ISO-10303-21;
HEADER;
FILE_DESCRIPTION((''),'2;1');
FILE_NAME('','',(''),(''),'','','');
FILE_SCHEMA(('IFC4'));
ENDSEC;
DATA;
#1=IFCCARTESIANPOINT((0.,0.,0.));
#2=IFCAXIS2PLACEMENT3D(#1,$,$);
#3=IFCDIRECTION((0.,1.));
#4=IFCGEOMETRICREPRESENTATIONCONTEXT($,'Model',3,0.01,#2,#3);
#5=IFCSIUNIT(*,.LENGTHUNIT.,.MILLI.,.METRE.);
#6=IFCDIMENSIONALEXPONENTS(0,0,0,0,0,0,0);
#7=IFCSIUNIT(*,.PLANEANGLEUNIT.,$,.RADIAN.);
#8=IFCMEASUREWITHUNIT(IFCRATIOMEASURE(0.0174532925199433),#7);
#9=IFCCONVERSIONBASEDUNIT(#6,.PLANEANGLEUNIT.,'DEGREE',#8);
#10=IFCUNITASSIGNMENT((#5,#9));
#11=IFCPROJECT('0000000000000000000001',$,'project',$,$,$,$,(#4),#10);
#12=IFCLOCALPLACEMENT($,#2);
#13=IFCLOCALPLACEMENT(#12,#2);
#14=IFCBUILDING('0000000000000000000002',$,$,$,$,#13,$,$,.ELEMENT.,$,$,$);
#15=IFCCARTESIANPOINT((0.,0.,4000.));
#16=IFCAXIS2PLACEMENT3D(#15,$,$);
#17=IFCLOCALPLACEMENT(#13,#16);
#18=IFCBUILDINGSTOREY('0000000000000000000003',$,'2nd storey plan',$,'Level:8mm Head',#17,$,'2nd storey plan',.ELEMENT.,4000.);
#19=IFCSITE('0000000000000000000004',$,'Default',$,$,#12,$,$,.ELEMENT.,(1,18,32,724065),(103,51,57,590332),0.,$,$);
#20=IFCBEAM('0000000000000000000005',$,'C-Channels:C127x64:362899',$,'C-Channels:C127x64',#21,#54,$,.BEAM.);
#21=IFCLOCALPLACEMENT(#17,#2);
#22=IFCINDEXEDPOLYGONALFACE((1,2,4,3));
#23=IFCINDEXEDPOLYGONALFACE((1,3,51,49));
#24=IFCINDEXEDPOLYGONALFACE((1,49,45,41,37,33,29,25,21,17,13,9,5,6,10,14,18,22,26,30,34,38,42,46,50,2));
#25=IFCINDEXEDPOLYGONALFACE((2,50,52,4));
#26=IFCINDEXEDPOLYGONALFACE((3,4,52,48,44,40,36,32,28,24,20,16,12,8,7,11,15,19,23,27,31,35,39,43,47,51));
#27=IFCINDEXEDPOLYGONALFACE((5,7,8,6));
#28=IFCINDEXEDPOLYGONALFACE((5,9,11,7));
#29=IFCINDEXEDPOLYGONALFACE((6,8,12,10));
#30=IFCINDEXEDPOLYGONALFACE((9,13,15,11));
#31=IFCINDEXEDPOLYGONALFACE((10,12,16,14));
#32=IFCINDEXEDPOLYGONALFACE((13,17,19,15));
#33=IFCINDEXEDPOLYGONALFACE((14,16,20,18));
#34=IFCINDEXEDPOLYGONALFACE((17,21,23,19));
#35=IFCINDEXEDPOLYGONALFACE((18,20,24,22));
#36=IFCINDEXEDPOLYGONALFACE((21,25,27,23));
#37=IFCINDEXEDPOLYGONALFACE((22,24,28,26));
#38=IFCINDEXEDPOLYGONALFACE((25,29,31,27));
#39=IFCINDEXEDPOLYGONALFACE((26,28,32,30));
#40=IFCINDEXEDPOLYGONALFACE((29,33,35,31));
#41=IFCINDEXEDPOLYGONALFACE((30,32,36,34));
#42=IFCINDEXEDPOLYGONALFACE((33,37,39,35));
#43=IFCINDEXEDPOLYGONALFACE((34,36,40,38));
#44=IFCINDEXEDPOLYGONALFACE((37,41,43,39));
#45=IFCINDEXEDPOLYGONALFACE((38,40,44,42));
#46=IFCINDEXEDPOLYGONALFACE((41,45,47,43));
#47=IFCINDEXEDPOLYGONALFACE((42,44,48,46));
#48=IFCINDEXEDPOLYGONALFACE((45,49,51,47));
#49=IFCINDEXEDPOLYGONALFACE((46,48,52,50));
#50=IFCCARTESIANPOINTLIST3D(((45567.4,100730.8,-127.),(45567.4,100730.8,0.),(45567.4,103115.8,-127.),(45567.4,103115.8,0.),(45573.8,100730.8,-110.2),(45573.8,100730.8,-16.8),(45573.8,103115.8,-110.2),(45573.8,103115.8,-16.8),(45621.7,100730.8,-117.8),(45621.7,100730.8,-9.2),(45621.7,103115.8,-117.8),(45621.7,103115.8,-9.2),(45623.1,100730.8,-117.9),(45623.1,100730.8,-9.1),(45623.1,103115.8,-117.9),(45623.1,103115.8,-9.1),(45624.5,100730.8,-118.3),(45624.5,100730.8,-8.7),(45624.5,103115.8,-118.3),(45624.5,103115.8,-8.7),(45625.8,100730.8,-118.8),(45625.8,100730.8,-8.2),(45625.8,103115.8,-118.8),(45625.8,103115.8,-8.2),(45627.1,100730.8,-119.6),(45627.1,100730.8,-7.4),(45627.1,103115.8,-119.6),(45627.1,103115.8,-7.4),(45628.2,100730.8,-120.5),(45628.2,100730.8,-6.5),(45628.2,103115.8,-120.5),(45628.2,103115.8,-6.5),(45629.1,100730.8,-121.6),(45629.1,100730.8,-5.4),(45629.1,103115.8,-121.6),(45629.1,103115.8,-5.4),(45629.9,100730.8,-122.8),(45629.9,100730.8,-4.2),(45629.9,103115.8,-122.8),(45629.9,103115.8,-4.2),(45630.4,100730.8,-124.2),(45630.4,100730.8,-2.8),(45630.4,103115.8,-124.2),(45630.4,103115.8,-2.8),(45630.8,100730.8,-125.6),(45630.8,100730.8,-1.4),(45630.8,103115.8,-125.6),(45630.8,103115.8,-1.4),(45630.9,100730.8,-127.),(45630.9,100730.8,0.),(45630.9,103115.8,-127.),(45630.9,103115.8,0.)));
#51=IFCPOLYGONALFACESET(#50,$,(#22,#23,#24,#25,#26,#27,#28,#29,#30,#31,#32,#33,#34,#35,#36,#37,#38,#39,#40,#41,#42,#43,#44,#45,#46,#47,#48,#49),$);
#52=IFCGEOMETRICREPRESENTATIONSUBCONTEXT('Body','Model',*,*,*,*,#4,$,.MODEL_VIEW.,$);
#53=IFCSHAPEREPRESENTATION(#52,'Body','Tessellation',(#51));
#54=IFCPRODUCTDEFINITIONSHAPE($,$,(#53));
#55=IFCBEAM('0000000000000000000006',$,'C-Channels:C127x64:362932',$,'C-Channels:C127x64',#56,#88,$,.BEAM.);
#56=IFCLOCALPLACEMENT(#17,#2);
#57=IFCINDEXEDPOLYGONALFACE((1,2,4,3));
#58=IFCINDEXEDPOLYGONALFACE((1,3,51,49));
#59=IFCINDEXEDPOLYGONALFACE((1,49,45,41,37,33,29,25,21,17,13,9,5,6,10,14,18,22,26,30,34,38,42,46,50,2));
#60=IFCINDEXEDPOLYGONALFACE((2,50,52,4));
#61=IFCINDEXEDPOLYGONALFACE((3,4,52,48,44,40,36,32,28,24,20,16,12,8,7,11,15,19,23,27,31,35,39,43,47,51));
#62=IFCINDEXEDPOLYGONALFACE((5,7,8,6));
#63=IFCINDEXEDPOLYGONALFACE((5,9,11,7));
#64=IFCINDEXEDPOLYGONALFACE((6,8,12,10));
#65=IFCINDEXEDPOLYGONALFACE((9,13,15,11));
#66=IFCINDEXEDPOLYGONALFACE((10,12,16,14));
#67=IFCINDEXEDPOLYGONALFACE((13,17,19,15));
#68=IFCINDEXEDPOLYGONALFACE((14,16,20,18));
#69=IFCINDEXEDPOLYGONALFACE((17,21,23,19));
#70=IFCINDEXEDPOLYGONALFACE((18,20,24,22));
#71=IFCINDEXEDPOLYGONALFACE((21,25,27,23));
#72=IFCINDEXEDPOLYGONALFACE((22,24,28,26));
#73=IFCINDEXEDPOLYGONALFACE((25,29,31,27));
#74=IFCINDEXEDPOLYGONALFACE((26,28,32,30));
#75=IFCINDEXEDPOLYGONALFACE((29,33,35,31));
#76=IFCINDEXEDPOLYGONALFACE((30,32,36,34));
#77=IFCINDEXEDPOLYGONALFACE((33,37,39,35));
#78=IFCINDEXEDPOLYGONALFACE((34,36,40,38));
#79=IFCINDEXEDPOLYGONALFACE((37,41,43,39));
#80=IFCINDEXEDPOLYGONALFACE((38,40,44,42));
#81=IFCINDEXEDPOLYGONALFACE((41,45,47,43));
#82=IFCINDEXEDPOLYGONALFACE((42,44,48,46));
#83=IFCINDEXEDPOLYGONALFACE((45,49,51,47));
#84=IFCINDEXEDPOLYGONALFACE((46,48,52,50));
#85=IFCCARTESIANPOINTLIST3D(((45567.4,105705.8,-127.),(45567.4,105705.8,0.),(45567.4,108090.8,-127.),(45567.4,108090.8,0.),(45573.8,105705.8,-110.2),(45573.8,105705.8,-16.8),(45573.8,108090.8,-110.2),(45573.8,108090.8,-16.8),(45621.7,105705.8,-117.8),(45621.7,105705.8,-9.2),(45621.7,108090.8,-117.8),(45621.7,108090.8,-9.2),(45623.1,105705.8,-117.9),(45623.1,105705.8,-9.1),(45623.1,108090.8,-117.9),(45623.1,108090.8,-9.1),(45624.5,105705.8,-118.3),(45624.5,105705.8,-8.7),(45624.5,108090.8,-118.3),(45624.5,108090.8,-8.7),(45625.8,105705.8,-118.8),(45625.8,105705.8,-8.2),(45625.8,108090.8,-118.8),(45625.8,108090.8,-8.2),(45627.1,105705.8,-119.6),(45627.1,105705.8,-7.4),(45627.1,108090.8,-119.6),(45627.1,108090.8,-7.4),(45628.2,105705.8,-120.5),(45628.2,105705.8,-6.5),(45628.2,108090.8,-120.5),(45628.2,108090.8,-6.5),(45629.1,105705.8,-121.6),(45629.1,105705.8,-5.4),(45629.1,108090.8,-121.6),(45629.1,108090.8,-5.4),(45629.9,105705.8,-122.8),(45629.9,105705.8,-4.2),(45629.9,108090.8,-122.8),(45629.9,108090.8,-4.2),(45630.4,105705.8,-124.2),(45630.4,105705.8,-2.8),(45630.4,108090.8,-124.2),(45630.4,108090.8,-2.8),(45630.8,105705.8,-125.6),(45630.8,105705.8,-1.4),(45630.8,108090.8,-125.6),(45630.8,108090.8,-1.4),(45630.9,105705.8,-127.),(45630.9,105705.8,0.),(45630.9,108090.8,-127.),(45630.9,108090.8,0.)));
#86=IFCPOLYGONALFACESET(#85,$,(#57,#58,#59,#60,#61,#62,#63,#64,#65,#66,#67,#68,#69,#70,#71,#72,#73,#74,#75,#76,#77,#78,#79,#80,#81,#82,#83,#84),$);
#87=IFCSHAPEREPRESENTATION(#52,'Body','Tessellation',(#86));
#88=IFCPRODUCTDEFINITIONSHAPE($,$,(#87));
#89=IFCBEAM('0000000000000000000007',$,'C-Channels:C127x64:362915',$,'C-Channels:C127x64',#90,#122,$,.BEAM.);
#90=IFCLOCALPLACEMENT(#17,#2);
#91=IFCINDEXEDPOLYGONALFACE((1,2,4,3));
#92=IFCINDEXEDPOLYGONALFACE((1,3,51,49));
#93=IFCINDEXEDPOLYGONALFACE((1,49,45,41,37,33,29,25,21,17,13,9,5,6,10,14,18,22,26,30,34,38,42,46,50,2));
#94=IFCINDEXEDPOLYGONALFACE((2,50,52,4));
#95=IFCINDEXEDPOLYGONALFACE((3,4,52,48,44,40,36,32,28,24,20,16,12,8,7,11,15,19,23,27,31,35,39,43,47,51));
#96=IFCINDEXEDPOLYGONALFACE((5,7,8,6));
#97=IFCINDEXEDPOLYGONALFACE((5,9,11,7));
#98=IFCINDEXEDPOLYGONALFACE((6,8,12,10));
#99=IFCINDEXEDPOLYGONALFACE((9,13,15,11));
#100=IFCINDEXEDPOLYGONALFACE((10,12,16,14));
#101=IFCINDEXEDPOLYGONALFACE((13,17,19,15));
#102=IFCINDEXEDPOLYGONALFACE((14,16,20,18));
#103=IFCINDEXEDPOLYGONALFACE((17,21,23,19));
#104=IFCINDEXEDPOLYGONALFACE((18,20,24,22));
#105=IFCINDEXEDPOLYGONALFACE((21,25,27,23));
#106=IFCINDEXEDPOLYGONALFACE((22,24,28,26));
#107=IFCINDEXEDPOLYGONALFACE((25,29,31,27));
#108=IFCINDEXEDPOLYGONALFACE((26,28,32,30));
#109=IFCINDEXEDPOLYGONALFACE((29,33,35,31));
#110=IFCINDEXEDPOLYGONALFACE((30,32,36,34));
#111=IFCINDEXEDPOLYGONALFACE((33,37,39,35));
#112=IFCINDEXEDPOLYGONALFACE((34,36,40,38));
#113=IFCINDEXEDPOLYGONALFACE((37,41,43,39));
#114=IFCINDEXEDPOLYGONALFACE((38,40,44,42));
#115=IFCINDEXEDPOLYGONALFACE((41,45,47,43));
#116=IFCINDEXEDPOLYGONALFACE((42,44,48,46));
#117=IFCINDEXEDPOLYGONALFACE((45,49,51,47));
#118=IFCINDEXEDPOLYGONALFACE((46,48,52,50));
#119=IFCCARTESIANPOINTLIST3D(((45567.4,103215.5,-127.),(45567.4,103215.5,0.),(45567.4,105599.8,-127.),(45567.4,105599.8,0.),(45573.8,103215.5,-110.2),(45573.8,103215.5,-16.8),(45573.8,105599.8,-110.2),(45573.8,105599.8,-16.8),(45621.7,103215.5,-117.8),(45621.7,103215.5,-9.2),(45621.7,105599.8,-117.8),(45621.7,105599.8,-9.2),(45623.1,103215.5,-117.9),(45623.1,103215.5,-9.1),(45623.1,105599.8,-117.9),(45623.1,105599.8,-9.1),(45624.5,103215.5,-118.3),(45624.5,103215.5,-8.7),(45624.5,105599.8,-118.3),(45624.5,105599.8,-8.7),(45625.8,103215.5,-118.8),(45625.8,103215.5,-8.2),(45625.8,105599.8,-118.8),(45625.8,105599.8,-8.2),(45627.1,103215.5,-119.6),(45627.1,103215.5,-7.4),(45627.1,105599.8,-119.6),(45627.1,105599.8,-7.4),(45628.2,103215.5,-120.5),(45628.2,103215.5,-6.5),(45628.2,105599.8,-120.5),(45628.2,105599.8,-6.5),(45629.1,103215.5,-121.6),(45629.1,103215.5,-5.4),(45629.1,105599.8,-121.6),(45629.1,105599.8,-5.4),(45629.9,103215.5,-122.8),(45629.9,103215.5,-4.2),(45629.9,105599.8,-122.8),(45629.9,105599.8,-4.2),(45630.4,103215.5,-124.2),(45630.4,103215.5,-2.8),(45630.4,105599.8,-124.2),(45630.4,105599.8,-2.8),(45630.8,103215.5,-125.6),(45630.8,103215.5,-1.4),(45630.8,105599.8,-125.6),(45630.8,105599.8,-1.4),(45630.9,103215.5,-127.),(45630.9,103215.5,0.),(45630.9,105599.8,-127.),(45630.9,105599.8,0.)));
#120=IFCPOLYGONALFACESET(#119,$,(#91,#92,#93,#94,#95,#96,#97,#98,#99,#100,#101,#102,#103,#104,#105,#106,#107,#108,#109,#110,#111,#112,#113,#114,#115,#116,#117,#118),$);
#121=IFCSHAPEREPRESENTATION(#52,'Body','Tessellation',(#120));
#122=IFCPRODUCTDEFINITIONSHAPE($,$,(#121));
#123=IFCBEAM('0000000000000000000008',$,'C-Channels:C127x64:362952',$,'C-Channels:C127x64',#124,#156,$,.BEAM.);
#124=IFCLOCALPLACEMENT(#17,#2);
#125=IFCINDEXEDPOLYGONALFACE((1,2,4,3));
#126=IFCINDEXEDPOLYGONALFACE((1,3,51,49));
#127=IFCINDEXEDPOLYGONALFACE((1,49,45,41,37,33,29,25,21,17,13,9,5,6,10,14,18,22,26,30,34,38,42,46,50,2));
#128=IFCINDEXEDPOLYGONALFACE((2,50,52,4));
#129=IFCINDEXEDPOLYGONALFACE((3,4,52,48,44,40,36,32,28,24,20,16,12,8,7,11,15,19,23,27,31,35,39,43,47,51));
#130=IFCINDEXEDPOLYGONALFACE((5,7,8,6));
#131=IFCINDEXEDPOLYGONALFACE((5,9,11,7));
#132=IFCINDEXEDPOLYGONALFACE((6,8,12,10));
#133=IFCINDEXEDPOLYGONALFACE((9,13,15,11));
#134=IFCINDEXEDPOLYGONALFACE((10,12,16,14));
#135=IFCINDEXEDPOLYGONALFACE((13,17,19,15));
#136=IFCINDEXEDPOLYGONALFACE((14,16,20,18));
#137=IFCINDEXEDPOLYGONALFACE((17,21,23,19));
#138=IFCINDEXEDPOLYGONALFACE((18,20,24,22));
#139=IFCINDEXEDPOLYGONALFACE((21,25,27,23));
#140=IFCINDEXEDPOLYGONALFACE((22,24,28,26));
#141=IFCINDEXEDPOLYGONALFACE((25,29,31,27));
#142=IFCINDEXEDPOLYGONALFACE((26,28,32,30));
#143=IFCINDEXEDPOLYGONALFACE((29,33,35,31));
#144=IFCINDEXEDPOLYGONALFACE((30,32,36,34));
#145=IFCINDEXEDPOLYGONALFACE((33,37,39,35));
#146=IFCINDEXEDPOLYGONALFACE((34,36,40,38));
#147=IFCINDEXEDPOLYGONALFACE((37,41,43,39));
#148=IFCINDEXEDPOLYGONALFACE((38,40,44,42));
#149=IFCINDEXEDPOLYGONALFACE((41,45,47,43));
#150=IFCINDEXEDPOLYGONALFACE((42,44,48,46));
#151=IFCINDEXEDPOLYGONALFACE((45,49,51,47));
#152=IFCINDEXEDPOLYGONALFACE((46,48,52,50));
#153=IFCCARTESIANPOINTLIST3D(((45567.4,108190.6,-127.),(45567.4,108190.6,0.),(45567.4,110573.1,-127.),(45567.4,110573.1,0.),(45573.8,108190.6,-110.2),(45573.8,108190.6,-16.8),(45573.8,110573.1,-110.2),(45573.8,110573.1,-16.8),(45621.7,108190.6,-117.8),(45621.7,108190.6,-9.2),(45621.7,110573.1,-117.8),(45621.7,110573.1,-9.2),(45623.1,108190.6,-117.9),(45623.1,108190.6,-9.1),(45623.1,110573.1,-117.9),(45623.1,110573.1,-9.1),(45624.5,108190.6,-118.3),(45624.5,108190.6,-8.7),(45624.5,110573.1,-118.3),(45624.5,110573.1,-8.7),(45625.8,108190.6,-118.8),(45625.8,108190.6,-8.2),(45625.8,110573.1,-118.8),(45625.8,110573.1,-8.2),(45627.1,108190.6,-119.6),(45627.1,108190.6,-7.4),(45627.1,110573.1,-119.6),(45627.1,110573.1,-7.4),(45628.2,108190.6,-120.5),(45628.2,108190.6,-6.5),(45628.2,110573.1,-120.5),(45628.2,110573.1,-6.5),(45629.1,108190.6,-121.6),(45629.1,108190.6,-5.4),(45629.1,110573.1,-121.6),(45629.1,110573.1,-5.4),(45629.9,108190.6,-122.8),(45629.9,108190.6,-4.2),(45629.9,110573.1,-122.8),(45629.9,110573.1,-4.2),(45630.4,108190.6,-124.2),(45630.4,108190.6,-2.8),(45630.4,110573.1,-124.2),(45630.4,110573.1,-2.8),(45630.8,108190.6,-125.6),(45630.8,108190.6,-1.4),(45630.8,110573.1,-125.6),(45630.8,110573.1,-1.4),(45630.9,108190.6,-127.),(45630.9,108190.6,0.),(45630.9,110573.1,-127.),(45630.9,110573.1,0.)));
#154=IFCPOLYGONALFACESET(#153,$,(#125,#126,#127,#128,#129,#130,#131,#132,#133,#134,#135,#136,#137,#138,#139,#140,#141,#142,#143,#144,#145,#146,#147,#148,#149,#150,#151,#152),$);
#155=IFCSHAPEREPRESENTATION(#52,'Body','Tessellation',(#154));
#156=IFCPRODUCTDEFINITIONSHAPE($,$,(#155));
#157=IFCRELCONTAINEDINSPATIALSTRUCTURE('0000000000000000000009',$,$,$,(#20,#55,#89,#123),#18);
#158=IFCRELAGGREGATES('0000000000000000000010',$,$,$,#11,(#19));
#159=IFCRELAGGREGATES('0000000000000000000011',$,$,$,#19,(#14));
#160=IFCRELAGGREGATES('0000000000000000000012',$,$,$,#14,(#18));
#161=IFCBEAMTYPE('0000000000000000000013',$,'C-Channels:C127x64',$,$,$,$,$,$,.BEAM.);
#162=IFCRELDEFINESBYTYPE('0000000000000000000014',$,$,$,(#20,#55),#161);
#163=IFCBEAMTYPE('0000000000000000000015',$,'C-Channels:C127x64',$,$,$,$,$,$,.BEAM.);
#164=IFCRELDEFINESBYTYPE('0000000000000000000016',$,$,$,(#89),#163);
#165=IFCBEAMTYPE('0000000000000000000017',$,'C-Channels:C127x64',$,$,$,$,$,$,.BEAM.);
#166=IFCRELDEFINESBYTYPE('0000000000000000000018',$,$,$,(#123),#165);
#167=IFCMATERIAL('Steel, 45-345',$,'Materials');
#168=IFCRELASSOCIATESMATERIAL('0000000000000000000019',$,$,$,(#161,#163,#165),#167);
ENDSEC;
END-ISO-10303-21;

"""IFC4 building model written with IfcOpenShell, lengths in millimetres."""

from ifc_helpers import new_model, entity, si_unit, converted_unit, direction, frame, origin, place, context, subcontext, project, spatial, indexed_curve, outline, extrude, source, transform, mapped, material, type_object, type_shapes, element, save


model = new_model("IFC4")

# Units and contexts
model_context = context("Model", 3, precision=0.01, world=origin(), true_north=direction((0.0, 1.0)))
body_context = subcontext(model_context, "Body", "Model", "MODEL_VIEW")
ifc_project = project(units=[si_unit("LENGTHUNIT", "METRE", prefix="MILLI"), converted_unit("PLANEANGLEUNIT", "DEGREE", entity("IfcRatioMeasure", 0.0174532925199433), si_unit("PLANEANGLEUNIT", "RADIAN"), dimensions=[0, 0, 0, 0, 0, 0, 0])], contexts=[model_context])

# Site, building, storey
site_placement = place(None, origin())
site = spatial("IfcSite", under=ifc_project, at=site_placement, Name="Default", CompositionType="ELEMENT", RefLatitude=(1, 18, 32, 724065), RefLongitude=(103, 51, 57, 590332), RefElevation=0.0)
building_placement = place(site_placement, origin())
building = spatial("IfcBuilding", under=site, at=building_placement, CompositionType="ELEMENT")
storey_placement = place(building_placement, frame((0.0, 0.0, 4000.0)))
storey = spatial("IfcBuildingStorey", under=building, at=storey_placement, Name="2nd storey plan", ObjectType="Level:8mm Head", LongName="2nd storey plan", CompositionType="ELEMENT", Elevation=4000.0)

# Beams
ifc_material_1 = material(Name="Steel, 45-345", Category="Materials")
beam_type_1 = type_object("IfcBeamType", Name="C-Channels:C127x64", PredefinedType="BEAM", material=ifc_material_1)
shared_shape_1 = source(origin(), body_context, "Body", "SweptSolid", [
    extrude(outline(indexed_curve([(-32.5, -63.5), (31.0, -63.5), (31.0, 63.5), (-32.4, 63.5), (-32.3, 62.1), (-32.0, 60.7), (-31.4, 59.3), (-30.7, 58.1), (-29.8, 57.0), (-28.7, 56.1), (-27.4, 55.3), (-26.1, 54.8), (-24.7, 54.4), (-23.2, 54.3), (24.6, 46.7), (24.6, -46.7), (-23.2, -54.3), (-24.7, -54.4), (-26.1, -54.8), (-27.4, -55.3), (-28.7, -56.1), (-29.8, -57.0), (-30.7, -58.1), (-31.4, -59.3), (-32.0, -60.7), (-32.3, -62.1), (-32.5, -63.5)], self_intersect=False)), frame((-1192.5, -11.7, 0.0), z_axis=(1.0, 0.0, 0.0), x_axis=(0.0, 1.0, 0.0)), (0.0, 0.0, 1.0), 2385.0),
])
type_shapes(beam_type_1, [shared_shape_1])
for number, where, z_axis, x_axis, name in (
    (1, (45586.8, 101923.3, -63.5), (0.0, 0.0, 1.0), (0.0, 1.0, 0.0), "C-Channels:C127x64:362899"),
    (2, (45586.8, 106898.3, -63.5), (0.0, 0.0, 1.0), (0.0, 1.0, 0.0), "C-Channels:C127x64:362932"),
):
    element("IfcBeam", number, at=place(storey_placement, frame(where, z_axis=z_axis, x_axis=x_axis)), inside=storey, type_object=beam_type_1, Name=name, ObjectType="C-Channels:C127x64", PredefinedType="BEAM", context=body_context, shape_type="MappedRepresentation", body=[
        mapped(shared_shape_1, transform((0.0, 0.0, 0.0), scale=1.0)),
    ])
beam_type_2 = type_object("IfcBeamType", Name="C-Channels:C127x64", PredefinedType="BEAM", material=ifc_material_1)
shared_shape_2 = source(origin(), body_context, "Body", "SweptSolid", [
    extrude(outline(indexed_curve([(-32.5, -63.5), (31.0, -63.5), (31.0, 63.5), (-32.4, 63.5), (-32.3, 62.1), (-32.0, 60.7), (-31.4, 59.3), (-30.7, 58.1), (-29.8, 57.0), (-28.7, 56.1), (-27.4, 55.3), (-26.1, 54.8), (-24.7, 54.4), (-23.2, 54.3), (24.6, 46.7), (24.6, -46.7), (-23.2, -54.3), (-24.7, -54.4), (-26.1, -54.8), (-27.4, -55.3), (-28.7, -56.1), (-29.8, -57.0), (-30.7, -58.1), (-31.4, -59.3), (-32.0, -60.7), (-32.3, -62.1), (-32.5, -63.5)], self_intersect=False)), frame((-1195.3, -11.7, 0.0), z_axis=(1.0, 0.0, 0.0), x_axis=(0.0, 1.0, 0.0)), (0.0, 0.0, 1.0), 2384.3),
])
type_shapes(beam_type_2, [shared_shape_2])
beam_1_placement = place(storey_placement, frame((45586.8, 104410.8, -63.5), z_axis=(0.0, 0.0, 1.0), x_axis=(0.0, 1.0, 0.0)))
element("IfcBeam", 3, at=beam_1_placement, inside=storey, type_object=beam_type_2, Name="C-Channels:C127x64:362915", ObjectType="C-Channels:C127x64", PredefinedType="BEAM", context=body_context, shape_type="MappedRepresentation", body=[
    mapped(shared_shape_2, transform((0.0, 0.0, 0.0), scale=1.0)),
])
beam_type_3 = type_object("IfcBeamType", Name="C-Channels:C127x64", PredefinedType="BEAM", material=ifc_material_1)
shared_shape_3 = source(origin(), body_context, "Body", "SweptSolid", [
    extrude(outline(indexed_curve([(-32.5, -63.5), (31.0, -63.5), (31.0, 63.5), (-32.4, 63.5), (-32.3, 62.1), (-32.0, 60.7), (-31.4, 59.3), (-30.7, 58.1), (-29.8, 57.0), (-28.7, 56.1), (-27.4, 55.3), (-26.1, 54.8), (-24.7, 54.4), (-23.2, 54.3), (24.6, 46.7), (24.6, -46.7), (-23.2, -54.3), (-24.7, -54.4), (-26.1, -54.8), (-27.4, -55.3), (-28.7, -56.1), (-29.8, -57.0), (-30.7, -58.1), (-31.4, -59.3), (-32.0, -60.7), (-32.3, -62.1), (-32.5, -63.5)], self_intersect=False)), frame((-1195.2, -11.7, 0.0), z_axis=(1.0, 0.0, 0.0), x_axis=(0.0, 1.0, 0.0)), (0.0, 0.0, 1.0), 2382.5),
])
type_shapes(beam_type_3, [shared_shape_3])
beam_2_placement = place(storey_placement, frame((45586.8, 109385.8, -63.5), z_axis=(0.0, 0.0, 1.0), x_axis=(0.0, 1.0, 0.0)))
element("IfcBeam", 4, at=beam_2_placement, inside=storey, type_object=beam_type_3, Name="C-Channels:C127x64:362952", ObjectType="C-Channels:C127x64", PredefinedType="BEAM", context=body_context, shape_type="MappedRepresentation", body=[
    mapped(shared_shape_3, transform((0.0, 0.0, 0.0), scale=1.0)),
])

save(model, "model.ifc")
